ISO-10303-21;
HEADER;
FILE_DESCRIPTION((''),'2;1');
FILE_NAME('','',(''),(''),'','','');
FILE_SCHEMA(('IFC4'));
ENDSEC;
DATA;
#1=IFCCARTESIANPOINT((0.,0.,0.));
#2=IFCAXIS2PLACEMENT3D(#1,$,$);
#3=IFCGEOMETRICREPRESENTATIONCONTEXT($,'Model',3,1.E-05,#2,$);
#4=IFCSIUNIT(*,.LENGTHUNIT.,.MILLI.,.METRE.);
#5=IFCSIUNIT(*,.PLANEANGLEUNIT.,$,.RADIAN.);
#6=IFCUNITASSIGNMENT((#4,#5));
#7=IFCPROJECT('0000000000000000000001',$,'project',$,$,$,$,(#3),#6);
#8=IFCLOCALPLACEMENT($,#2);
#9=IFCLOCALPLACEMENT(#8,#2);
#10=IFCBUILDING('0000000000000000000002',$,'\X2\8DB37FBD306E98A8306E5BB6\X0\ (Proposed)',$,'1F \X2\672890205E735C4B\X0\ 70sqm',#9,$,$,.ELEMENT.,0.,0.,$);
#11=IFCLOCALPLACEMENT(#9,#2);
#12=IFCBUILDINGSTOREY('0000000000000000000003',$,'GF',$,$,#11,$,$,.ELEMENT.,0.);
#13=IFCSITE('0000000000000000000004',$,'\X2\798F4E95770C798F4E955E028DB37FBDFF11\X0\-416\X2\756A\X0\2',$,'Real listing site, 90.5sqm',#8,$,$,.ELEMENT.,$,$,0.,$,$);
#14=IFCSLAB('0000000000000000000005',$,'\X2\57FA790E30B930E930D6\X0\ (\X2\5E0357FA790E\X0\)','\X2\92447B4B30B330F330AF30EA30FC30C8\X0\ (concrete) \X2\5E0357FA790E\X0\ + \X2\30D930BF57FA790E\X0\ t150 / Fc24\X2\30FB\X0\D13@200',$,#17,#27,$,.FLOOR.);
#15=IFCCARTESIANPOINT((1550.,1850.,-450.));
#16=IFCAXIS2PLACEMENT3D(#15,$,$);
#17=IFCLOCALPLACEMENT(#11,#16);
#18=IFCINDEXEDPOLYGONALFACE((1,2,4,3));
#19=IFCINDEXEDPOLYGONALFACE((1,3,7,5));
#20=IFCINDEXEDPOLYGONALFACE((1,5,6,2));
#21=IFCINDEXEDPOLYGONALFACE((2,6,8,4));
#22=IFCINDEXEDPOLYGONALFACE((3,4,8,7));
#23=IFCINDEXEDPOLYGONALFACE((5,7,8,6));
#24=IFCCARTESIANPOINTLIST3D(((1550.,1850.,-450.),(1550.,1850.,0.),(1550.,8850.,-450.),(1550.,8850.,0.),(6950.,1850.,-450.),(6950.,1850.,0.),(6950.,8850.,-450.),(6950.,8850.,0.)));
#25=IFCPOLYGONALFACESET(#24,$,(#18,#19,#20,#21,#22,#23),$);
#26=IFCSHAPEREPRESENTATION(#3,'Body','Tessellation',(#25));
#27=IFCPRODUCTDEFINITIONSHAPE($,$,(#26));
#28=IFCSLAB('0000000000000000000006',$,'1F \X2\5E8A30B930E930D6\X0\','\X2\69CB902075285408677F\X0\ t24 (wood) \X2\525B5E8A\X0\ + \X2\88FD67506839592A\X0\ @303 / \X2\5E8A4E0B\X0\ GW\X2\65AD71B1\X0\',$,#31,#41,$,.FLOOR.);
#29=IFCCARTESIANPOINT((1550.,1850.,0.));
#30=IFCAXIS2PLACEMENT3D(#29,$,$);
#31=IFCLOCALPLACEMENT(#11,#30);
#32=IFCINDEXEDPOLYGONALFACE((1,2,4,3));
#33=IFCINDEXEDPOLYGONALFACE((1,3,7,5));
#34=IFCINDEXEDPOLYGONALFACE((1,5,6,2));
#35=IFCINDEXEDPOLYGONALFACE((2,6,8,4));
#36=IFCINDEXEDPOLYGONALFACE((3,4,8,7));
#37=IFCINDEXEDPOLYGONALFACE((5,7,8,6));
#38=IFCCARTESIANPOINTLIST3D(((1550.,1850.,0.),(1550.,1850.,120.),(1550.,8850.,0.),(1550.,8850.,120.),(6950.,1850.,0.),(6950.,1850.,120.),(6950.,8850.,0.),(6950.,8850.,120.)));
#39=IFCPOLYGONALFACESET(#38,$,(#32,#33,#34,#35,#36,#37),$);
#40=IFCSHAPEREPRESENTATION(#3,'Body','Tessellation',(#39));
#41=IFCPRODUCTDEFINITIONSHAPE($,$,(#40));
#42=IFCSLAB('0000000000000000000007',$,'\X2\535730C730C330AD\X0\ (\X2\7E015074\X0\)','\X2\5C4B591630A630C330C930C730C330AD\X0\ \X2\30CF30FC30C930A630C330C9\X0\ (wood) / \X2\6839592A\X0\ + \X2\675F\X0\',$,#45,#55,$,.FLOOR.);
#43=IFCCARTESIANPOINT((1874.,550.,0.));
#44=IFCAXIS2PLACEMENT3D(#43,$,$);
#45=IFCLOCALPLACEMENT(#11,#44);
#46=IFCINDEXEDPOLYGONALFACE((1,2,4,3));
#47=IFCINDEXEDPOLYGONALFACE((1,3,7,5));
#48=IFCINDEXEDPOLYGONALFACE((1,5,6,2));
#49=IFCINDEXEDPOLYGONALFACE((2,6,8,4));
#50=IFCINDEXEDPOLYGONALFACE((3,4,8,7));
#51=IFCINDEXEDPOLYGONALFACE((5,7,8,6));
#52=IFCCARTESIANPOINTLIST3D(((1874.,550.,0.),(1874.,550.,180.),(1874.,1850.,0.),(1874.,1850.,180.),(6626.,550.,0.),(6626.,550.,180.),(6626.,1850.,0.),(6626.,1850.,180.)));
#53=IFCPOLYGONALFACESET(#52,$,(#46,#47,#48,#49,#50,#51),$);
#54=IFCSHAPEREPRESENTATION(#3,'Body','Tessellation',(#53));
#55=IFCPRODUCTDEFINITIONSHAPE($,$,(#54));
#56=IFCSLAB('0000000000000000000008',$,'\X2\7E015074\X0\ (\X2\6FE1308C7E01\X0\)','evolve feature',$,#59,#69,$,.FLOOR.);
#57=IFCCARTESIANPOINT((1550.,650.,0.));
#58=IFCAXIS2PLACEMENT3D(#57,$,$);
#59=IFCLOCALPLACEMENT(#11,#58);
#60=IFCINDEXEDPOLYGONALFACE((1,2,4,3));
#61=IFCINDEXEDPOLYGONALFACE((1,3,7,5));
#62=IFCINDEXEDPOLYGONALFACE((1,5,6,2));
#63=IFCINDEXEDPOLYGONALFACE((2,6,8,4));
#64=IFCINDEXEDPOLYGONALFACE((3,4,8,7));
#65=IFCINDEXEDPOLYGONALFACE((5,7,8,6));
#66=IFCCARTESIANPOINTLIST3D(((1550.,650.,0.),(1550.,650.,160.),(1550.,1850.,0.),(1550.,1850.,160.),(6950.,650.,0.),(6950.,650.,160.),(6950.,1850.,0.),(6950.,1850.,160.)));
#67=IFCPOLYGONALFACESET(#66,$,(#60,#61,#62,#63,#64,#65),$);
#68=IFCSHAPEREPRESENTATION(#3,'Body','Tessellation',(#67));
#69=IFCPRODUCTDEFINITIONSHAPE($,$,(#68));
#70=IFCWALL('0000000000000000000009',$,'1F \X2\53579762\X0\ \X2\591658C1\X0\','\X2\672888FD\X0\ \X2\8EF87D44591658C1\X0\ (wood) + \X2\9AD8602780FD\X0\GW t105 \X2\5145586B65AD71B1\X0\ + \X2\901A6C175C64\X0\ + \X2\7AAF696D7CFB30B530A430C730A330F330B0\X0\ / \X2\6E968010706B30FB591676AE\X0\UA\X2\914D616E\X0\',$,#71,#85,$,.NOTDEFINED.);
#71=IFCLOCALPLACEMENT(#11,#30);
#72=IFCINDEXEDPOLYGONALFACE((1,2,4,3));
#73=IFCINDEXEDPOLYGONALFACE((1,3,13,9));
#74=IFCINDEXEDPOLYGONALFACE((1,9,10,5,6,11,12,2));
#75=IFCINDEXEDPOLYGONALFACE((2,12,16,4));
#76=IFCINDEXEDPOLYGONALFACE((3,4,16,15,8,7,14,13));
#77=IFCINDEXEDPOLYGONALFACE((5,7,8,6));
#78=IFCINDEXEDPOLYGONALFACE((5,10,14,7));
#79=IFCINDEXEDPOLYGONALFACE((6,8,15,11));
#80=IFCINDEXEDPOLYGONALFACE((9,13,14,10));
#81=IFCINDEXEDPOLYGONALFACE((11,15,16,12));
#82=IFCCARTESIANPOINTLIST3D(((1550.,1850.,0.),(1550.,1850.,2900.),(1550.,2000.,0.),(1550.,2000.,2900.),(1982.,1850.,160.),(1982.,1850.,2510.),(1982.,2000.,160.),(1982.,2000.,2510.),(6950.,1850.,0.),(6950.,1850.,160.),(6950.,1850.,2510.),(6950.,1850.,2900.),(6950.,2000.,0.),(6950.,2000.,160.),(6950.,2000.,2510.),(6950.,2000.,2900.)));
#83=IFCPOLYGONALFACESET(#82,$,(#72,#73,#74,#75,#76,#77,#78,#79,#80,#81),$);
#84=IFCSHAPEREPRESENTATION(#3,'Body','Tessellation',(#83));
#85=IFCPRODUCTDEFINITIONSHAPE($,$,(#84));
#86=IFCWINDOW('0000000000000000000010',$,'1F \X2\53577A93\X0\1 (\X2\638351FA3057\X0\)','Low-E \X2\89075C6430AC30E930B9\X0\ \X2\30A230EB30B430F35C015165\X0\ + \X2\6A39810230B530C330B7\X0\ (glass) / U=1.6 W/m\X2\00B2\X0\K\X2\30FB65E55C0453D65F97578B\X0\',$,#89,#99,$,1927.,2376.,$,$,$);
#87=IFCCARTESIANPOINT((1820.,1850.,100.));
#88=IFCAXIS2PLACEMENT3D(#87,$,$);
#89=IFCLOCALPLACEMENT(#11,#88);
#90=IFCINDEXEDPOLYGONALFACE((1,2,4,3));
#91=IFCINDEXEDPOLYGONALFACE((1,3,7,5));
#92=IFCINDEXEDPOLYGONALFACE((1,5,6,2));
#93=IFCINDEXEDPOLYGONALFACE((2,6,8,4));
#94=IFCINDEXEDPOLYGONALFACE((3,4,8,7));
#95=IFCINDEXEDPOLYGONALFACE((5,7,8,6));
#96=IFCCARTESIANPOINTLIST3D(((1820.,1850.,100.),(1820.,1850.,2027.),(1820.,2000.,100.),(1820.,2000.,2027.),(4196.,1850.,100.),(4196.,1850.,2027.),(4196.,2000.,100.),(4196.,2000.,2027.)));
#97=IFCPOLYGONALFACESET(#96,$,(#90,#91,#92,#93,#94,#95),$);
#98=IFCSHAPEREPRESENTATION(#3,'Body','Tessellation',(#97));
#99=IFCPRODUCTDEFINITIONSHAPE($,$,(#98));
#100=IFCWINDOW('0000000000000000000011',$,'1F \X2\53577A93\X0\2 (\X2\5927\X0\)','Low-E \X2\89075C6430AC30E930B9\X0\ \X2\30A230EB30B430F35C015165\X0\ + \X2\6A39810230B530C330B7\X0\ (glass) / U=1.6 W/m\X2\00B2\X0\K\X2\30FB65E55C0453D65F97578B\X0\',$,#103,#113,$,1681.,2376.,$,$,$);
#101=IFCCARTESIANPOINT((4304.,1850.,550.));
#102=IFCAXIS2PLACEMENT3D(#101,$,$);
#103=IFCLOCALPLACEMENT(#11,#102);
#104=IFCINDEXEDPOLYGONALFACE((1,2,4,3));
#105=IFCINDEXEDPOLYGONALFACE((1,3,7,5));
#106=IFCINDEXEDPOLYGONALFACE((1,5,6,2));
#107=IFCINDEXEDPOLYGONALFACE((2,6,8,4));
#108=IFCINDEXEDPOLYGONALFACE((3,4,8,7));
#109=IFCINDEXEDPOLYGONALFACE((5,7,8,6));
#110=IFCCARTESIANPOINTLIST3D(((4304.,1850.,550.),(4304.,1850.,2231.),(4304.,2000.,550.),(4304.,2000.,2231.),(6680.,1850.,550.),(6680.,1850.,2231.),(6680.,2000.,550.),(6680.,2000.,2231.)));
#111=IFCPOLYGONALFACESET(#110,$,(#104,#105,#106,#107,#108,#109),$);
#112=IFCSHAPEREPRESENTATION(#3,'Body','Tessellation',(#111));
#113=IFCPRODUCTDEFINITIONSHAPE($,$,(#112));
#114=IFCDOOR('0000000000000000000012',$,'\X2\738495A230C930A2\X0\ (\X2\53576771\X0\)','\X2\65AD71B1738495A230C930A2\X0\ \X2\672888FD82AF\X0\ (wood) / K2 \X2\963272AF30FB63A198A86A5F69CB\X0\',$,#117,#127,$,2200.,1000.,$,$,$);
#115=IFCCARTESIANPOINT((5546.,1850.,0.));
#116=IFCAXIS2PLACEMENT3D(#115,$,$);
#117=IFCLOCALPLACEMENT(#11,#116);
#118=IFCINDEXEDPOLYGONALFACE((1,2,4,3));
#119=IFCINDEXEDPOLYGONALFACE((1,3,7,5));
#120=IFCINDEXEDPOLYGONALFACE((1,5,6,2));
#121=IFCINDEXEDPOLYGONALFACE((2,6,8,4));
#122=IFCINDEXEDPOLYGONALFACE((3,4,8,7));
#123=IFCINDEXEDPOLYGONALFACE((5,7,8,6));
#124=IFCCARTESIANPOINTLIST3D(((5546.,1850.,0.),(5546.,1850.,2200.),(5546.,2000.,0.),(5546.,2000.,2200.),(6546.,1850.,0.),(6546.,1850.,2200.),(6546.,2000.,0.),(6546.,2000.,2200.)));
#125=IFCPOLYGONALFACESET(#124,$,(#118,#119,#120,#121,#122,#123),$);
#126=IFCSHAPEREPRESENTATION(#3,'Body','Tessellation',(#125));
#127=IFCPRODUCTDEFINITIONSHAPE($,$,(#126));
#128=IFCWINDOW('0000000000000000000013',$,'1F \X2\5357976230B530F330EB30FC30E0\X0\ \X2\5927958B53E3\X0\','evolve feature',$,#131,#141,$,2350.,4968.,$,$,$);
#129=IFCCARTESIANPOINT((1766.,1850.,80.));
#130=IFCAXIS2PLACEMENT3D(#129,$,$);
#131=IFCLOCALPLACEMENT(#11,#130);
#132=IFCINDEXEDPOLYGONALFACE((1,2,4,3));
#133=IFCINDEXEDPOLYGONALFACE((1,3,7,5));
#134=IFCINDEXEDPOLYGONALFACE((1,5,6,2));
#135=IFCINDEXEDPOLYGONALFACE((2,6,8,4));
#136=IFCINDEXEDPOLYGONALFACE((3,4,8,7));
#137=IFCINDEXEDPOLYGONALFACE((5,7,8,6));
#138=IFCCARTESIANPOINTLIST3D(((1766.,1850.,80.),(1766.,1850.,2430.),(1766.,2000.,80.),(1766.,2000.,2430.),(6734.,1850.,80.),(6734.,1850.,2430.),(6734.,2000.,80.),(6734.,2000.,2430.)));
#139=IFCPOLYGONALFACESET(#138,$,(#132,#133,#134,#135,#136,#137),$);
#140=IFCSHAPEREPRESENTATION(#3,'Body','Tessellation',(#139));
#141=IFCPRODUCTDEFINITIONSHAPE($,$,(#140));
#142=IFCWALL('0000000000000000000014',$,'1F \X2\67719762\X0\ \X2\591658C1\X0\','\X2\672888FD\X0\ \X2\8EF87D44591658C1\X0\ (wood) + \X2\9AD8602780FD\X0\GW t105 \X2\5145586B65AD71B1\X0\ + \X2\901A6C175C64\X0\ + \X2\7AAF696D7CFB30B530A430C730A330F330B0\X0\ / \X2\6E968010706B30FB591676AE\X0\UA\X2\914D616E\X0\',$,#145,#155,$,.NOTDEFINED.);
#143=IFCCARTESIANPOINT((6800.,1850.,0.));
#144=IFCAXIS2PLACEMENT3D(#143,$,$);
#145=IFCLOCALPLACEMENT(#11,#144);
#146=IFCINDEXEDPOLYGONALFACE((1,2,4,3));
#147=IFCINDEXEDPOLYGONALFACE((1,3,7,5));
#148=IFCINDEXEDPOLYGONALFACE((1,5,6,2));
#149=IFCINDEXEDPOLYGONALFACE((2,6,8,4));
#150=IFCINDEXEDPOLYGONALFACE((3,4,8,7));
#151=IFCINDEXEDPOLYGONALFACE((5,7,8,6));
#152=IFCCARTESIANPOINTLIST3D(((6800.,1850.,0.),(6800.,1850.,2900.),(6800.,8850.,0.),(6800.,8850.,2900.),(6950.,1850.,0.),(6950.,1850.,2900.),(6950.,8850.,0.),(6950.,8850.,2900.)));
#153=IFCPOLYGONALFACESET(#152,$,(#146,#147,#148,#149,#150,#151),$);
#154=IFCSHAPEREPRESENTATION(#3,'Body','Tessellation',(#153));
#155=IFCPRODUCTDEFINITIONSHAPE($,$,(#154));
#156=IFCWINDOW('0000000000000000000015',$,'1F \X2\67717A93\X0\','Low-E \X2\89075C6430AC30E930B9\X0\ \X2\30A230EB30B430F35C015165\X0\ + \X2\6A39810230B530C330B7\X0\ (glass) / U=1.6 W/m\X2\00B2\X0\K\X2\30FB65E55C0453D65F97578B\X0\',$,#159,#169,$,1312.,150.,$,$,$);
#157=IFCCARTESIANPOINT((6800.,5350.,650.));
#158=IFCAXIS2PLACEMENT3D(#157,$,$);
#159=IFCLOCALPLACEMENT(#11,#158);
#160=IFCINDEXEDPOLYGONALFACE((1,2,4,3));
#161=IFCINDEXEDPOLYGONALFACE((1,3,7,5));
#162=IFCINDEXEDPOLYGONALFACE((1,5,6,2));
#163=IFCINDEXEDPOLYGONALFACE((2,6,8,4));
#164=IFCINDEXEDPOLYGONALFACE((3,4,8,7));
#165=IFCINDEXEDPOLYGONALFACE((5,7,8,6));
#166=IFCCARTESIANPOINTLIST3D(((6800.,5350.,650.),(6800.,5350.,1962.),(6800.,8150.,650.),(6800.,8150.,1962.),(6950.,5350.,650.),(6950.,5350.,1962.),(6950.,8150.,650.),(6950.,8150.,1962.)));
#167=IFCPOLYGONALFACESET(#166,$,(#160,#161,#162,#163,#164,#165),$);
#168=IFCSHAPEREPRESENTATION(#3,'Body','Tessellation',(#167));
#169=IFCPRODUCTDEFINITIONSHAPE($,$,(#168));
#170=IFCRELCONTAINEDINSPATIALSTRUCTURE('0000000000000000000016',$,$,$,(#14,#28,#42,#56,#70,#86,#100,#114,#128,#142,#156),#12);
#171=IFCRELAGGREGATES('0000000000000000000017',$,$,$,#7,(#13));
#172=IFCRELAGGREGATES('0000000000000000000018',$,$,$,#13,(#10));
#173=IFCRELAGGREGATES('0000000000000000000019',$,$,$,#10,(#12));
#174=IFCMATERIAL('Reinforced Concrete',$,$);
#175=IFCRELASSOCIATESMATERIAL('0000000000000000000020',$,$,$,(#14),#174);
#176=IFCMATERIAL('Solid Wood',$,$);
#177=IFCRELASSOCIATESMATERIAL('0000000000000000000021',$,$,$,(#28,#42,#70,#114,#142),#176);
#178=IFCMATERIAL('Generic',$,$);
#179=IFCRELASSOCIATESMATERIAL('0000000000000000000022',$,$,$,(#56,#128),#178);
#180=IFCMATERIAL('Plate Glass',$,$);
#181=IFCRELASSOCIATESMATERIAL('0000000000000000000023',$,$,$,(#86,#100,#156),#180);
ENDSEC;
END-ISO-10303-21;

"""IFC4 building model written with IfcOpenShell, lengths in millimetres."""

from ifc_helpers import new_model, si_unit, frame, frame_2d, origin, place, context, project, spatial, rectangle, extrude, material, element, fill, save


model = new_model("IFC4")

# Units and contexts
model_context = context("Model", 3, precision=1e-05, world=origin())
ifc_project = project(units=[si_unit("LENGTHUNIT", "METRE", prefix="MILLI"), si_unit("PLANEANGLEUNIT", "RADIAN")], contexts=[model_context])

# Site, building, storey
site_placement = place(None, origin())
site = spatial("IfcSite", under=ifc_project, at=site_placement, Name="福井県福井市足羽１-416番2", ObjectType="Real listing site, 90.5sqm", CompositionType="ELEMENT", RefElevation=0.0)
building_placement = place(site_placement, origin())
building = spatial("IfcBuilding", under=site, at=building_placement, Name="足羽の風の家 (Proposed)", ObjectType="1F 木造平屋 70sqm", CompositionType="ELEMENT", ElevationOfRefHeight=0.0, ElevationOfTerrain=0.0)
storey_placement = place(building_placement, origin())
storey = spatial("IfcBuildingStorey", under=building, at=storey_placement, Name="GF", CompositionType="ELEMENT", Elevation=0.0)

# Slabs
ifc_material_1 = material(Name="Reinforced Concrete")
slab_1_placement = place(storey_placement, frame((1550.0, 1850.0, -450.0)))
element("IfcSlab", 1, at=slab_1_placement, inside=storey, material=ifc_material_1, Name="基礎スラブ (布基礎)", Description="鉄筋コンクリート (concrete) 布基礎 + ベタ基礎 t150 / Fc24・D13@200", PredefinedType="FLOOR", context=model_context, shape_type="SweptSolid", body=[
    extrude(rectangle(XDim=5400.0, YDim=7000.0, at=frame_2d((2700.0, 3500.0))), frame((1550.0, 1850.0, -450.0)), (0.0, 0.0, 1.0), 450.0),
])
ifc_material_2 = material(Name="Solid Wood")
slab_2_placement = place(storey_placement, frame((1550.0, 1850.0, 0.0)))
element("IfcSlab", 2, at=slab_2_placement, inside=storey, material=ifc_material_2, Name="1F 床スラブ", Description="構造用合板 t24 (wood) 剛床 + 製材根太 @303 / 床下 GW断熱", PredefinedType="FLOOR", context=model_context, shape_type="SweptSolid", body=[
    extrude(rectangle(XDim=5400.0, YDim=7000.0, at=frame_2d((2700.0, 3500.0))), frame((1550.0, 1850.0, 0.0)), (0.0, 0.0, 1.0), 120.0),
])
slab_3_placement = place(storey_placement, frame((1874.0, 550.0, 0.0)))
element("IfcSlab", 3, at=slab_3_placement, inside=storey, material=ifc_material_2, Name="南デッキ (縁側)", Description="屋外ウッドデッキ ハードウッド (wood) / 根太 + 束", PredefinedType="FLOOR", context=model_context, shape_type="SweptSolid", body=[
    extrude(rectangle(XDim=4752.0, YDim=1300.0, at=frame_2d((2376.0, 650.0))), frame((1874.0, 550.0, 0.0)), (0.0, 0.0, 1.0), 180.0),
])
ifc_material_3 = material(Name="Generic")
slab_4_placement = place(storey_placement, frame((1550.0, 650.0, 0.0)))
element("IfcSlab", 4, at=slab_4_placement, inside=storey, material=ifc_material_3, Name="縁側 (濡れ縁)", Description="evolve feature", PredefinedType="FLOOR", context=model_context, shape_type="SweptSolid", body=[
    extrude(rectangle(XDim=5400.0, YDim=1200.0, at=frame_2d((2700.0, 600.0))), frame((1550.0, 650.0, 0.0)), (0.0, 0.0, 1.0), 160.0),
])

# Wall, openings, windows, door
wall_1_placement = place(storey_placement, frame((1550.0, 1850.0, 0.0)))
wall_1 = element("IfcWall", 5, at=wall_1_placement, inside=storey, material=ifc_material_2, Name="1F 南面 外壁", Description="木製 軸組外壁 (wood) + 高性能GW t105 充填断熱 + 通気層 + 窯業系サイディング / 準耐火・外皮UA配慮", PredefinedType="NOTDEFINED", context=model_context, shape_type="SweptSolid", body=[
    extrude(rectangle(XDim=5400.0, YDim=150.0, at=frame_2d((2700.0, 75.0))), frame((1550.0, 1850.0, 0.0)), (0.0, 0.0, 1.0), 2900.0),
])
opening_1_placement = place(storey_placement, frame((1820.0, 1850.0, 100.0)))
opening_1 = element("IfcOpeningElement", 6, at=opening_1_placement, cuts=wall_1, PredefinedType="NOTDEFINED", context=model_context, shape_type="SweptSolid", body=[
    extrude(rectangle(XDim=2376.0, YDim=150.0, at=frame_2d((1188.0, 75.0))), frame((1820.0, 1850.0, 100.0)), (0.0, 0.0, 1.0), 1927.0),
])
opening_2_placement = place(storey_placement, frame((4304.0, 1850.0, 550.0)))
opening_2 = element("IfcOpeningElement", 7, at=opening_2_placement, cuts=wall_1, PredefinedType="NOTDEFINED", context=model_context, shape_type="SweptSolid", body=[
    extrude(rectangle(XDim=2376.0, YDim=150.0, at=frame_2d((1188.0, 75.0))), frame((4304.0, 1850.0, 550.0)), (0.0, 0.0, 1.0), 1681.0),
])
opening_3_placement = place(storey_placement, frame((5546.0, 1850.0, 0.0)))
opening_3 = element("IfcOpeningElement", 8, at=opening_3_placement, cuts=wall_1, PredefinedType="NOTDEFINED", context=model_context, shape_type="SweptSolid", body=[
    extrude(rectangle(XDim=1000.0, YDim=150.0, at=frame_2d((500.0, 75.0))), frame((5546.0, 1850.0, 0.0)), (0.0, 0.0, 1.0), 2200.0),
])
opening_4_placement = place(storey_placement, frame((1766.0, 1850.0, 80.0)))
opening_4 = element("IfcOpeningElement", 9, at=opening_4_placement, cuts=wall_1, PredefinedType="NOTDEFINED", context=model_context, shape_type="SweptSolid", body=[
    extrude(rectangle(XDim=4968.0, YDim=150.0, at=frame_2d((2484.0, 75.0))), frame((1766.0, 1850.0, 80.0)), (0.0, 0.0, 1.0), 2350.0),
])
ifc_material_4 = material(Name="Plate Glass")
window_1_placement = place(storey_placement, frame((1820.0, 1850.0, 100.0)))
window_1 = element("IfcWindow", 10, at=window_1_placement, inside=storey, material=ifc_material_4, Name="1F 南窓1 (掃出し)", Description="Low-E 複層ガラス アルゴン封入 + 樹脂サッシ (glass) / U=1.6 W/m²K・日射取得型", OverallHeight=1927.0, OverallWidth=2376.0, context=model_context, shape_type="SweptSolid", body=[
    extrude(rectangle(XDim=2376.0, YDim=150.0, at=frame_2d((1188.0, 75.0))), frame((1820.0, 1850.0, 100.0)), (0.0, 0.0, 1.0), 1927.0),
])
fill(opening_1, window_1)
window_2_placement = place(storey_placement, frame((4304.0, 1850.0, 550.0)))
window_2 = element("IfcWindow", 11, at=window_2_placement, inside=storey, material=ifc_material_4, Name="1F 南窓2 (大)", Description="Low-E 複層ガラス アルゴン封入 + 樹脂サッシ (glass) / U=1.6 W/m²K・日射取得型", OverallHeight=1681.0, OverallWidth=2376.0, context=model_context, shape_type="SweptSolid", body=[
    extrude(rectangle(XDim=2376.0, YDim=150.0, at=frame_2d((1188.0, 75.0))), frame((4304.0, 1850.0, 550.0)), (0.0, 0.0, 1.0), 1681.0),
])
fill(opening_2, window_2)
door_placement = place(storey_placement, frame((5546.0, 1850.0, 0.0)))
door = element("IfcDoor", 12, at=door_placement, inside=storey, material=ifc_material_2, Name="玄関ドア (南東)", Description="断熱玄関ドア 木製芯 (wood) / K2 防犯・採風機構", OverallHeight=2200.0, OverallWidth=1000.0, context=model_context, shape_type="SweptSolid", body=[
    extrude(rectangle(XDim=1000.0, YDim=150.0, at=frame_2d((500.0, 75.0))), frame((5546.0, 1850.0, 0.0)), (0.0, 0.0, 1.0), 2200.0),
])
fill(opening_3, door)
window_3_placement = place(storey_placement, frame((1766.0, 1850.0, 80.0)))
window_3 = element("IfcWindow", 13, at=window_3_placement, inside=storey, material=ifc_material_3, Name="1F 南面サンルーム 大開口", Description="evolve feature", OverallHeight=2350.0, OverallWidth=4968.0, context=model_context, shape_type="SweptSolid", body=[
    extrude(rectangle(XDim=4968.0, YDim=150.0, at=frame_2d((2484.0, 75.0))), frame((1766.0, 1850.0, 80.0)), (0.0, 0.0, 1.0), 2350.0),
])
fill(opening_4, window_3)

# Wall, opening, window
wall_2_placement = place(storey_placement, frame((6800.0, 1850.0, 0.0)))
wall_2 = element("IfcWall", 14, at=wall_2_placement, inside=storey, material=ifc_material_2, Name="1F 東面 外壁", Description="木製 軸組外壁 (wood) + 高性能GW t105 充填断熱 + 通気層 + 窯業系サイディング / 準耐火・外皮UA配慮", PredefinedType="NOTDEFINED", context=model_context, shape_type="SweptSolid", body=[
    extrude(rectangle(XDim=150.0, YDim=7000.0, at=frame_2d((75.0, 3500.0))), frame((6800.0, 1850.0, 0.0)), (0.0, 0.0, 1.0), 2900.0),
])
opening_5_placement = place(storey_placement, frame((6800.0, 5350.0, 650.0)))
opening_5 = element("IfcOpeningElement", 15, at=opening_5_placement, cuts=wall_2, PredefinedType="NOTDEFINED", context=model_context, shape_type="SweptSolid", body=[
    extrude(rectangle(XDim=150.0, YDim=2800.0, at=frame_2d((75.0, 1400.0))), frame((6800.0, 5350.0, 650.0)), (0.0, 0.0, 1.0), 1312.0),
])
window_4_placement = place(storey_placement, frame((6800.0, 5350.0, 650.0)))
window_4 = element("IfcWindow", 16, at=window_4_placement, inside=storey, material=ifc_material_4, Name="1F 東窓", Description="Low-E 複層ガラス アルゴン封入 + 樹脂サッシ (glass) / U=1.6 W/m²K・日射取得型", OverallHeight=1312.0, OverallWidth=150.0, context=model_context, shape_type="SweptSolid", body=[
    extrude(rectangle(XDim=150.0, YDim=2800.0, at=frame_2d((75.0, 1400.0))), frame((6800.0, 5350.0, 650.0)), (0.0, 0.0, 1.0), 1312.0),
])
fill(opening_5, window_4)

save(model, "model.ifc")
